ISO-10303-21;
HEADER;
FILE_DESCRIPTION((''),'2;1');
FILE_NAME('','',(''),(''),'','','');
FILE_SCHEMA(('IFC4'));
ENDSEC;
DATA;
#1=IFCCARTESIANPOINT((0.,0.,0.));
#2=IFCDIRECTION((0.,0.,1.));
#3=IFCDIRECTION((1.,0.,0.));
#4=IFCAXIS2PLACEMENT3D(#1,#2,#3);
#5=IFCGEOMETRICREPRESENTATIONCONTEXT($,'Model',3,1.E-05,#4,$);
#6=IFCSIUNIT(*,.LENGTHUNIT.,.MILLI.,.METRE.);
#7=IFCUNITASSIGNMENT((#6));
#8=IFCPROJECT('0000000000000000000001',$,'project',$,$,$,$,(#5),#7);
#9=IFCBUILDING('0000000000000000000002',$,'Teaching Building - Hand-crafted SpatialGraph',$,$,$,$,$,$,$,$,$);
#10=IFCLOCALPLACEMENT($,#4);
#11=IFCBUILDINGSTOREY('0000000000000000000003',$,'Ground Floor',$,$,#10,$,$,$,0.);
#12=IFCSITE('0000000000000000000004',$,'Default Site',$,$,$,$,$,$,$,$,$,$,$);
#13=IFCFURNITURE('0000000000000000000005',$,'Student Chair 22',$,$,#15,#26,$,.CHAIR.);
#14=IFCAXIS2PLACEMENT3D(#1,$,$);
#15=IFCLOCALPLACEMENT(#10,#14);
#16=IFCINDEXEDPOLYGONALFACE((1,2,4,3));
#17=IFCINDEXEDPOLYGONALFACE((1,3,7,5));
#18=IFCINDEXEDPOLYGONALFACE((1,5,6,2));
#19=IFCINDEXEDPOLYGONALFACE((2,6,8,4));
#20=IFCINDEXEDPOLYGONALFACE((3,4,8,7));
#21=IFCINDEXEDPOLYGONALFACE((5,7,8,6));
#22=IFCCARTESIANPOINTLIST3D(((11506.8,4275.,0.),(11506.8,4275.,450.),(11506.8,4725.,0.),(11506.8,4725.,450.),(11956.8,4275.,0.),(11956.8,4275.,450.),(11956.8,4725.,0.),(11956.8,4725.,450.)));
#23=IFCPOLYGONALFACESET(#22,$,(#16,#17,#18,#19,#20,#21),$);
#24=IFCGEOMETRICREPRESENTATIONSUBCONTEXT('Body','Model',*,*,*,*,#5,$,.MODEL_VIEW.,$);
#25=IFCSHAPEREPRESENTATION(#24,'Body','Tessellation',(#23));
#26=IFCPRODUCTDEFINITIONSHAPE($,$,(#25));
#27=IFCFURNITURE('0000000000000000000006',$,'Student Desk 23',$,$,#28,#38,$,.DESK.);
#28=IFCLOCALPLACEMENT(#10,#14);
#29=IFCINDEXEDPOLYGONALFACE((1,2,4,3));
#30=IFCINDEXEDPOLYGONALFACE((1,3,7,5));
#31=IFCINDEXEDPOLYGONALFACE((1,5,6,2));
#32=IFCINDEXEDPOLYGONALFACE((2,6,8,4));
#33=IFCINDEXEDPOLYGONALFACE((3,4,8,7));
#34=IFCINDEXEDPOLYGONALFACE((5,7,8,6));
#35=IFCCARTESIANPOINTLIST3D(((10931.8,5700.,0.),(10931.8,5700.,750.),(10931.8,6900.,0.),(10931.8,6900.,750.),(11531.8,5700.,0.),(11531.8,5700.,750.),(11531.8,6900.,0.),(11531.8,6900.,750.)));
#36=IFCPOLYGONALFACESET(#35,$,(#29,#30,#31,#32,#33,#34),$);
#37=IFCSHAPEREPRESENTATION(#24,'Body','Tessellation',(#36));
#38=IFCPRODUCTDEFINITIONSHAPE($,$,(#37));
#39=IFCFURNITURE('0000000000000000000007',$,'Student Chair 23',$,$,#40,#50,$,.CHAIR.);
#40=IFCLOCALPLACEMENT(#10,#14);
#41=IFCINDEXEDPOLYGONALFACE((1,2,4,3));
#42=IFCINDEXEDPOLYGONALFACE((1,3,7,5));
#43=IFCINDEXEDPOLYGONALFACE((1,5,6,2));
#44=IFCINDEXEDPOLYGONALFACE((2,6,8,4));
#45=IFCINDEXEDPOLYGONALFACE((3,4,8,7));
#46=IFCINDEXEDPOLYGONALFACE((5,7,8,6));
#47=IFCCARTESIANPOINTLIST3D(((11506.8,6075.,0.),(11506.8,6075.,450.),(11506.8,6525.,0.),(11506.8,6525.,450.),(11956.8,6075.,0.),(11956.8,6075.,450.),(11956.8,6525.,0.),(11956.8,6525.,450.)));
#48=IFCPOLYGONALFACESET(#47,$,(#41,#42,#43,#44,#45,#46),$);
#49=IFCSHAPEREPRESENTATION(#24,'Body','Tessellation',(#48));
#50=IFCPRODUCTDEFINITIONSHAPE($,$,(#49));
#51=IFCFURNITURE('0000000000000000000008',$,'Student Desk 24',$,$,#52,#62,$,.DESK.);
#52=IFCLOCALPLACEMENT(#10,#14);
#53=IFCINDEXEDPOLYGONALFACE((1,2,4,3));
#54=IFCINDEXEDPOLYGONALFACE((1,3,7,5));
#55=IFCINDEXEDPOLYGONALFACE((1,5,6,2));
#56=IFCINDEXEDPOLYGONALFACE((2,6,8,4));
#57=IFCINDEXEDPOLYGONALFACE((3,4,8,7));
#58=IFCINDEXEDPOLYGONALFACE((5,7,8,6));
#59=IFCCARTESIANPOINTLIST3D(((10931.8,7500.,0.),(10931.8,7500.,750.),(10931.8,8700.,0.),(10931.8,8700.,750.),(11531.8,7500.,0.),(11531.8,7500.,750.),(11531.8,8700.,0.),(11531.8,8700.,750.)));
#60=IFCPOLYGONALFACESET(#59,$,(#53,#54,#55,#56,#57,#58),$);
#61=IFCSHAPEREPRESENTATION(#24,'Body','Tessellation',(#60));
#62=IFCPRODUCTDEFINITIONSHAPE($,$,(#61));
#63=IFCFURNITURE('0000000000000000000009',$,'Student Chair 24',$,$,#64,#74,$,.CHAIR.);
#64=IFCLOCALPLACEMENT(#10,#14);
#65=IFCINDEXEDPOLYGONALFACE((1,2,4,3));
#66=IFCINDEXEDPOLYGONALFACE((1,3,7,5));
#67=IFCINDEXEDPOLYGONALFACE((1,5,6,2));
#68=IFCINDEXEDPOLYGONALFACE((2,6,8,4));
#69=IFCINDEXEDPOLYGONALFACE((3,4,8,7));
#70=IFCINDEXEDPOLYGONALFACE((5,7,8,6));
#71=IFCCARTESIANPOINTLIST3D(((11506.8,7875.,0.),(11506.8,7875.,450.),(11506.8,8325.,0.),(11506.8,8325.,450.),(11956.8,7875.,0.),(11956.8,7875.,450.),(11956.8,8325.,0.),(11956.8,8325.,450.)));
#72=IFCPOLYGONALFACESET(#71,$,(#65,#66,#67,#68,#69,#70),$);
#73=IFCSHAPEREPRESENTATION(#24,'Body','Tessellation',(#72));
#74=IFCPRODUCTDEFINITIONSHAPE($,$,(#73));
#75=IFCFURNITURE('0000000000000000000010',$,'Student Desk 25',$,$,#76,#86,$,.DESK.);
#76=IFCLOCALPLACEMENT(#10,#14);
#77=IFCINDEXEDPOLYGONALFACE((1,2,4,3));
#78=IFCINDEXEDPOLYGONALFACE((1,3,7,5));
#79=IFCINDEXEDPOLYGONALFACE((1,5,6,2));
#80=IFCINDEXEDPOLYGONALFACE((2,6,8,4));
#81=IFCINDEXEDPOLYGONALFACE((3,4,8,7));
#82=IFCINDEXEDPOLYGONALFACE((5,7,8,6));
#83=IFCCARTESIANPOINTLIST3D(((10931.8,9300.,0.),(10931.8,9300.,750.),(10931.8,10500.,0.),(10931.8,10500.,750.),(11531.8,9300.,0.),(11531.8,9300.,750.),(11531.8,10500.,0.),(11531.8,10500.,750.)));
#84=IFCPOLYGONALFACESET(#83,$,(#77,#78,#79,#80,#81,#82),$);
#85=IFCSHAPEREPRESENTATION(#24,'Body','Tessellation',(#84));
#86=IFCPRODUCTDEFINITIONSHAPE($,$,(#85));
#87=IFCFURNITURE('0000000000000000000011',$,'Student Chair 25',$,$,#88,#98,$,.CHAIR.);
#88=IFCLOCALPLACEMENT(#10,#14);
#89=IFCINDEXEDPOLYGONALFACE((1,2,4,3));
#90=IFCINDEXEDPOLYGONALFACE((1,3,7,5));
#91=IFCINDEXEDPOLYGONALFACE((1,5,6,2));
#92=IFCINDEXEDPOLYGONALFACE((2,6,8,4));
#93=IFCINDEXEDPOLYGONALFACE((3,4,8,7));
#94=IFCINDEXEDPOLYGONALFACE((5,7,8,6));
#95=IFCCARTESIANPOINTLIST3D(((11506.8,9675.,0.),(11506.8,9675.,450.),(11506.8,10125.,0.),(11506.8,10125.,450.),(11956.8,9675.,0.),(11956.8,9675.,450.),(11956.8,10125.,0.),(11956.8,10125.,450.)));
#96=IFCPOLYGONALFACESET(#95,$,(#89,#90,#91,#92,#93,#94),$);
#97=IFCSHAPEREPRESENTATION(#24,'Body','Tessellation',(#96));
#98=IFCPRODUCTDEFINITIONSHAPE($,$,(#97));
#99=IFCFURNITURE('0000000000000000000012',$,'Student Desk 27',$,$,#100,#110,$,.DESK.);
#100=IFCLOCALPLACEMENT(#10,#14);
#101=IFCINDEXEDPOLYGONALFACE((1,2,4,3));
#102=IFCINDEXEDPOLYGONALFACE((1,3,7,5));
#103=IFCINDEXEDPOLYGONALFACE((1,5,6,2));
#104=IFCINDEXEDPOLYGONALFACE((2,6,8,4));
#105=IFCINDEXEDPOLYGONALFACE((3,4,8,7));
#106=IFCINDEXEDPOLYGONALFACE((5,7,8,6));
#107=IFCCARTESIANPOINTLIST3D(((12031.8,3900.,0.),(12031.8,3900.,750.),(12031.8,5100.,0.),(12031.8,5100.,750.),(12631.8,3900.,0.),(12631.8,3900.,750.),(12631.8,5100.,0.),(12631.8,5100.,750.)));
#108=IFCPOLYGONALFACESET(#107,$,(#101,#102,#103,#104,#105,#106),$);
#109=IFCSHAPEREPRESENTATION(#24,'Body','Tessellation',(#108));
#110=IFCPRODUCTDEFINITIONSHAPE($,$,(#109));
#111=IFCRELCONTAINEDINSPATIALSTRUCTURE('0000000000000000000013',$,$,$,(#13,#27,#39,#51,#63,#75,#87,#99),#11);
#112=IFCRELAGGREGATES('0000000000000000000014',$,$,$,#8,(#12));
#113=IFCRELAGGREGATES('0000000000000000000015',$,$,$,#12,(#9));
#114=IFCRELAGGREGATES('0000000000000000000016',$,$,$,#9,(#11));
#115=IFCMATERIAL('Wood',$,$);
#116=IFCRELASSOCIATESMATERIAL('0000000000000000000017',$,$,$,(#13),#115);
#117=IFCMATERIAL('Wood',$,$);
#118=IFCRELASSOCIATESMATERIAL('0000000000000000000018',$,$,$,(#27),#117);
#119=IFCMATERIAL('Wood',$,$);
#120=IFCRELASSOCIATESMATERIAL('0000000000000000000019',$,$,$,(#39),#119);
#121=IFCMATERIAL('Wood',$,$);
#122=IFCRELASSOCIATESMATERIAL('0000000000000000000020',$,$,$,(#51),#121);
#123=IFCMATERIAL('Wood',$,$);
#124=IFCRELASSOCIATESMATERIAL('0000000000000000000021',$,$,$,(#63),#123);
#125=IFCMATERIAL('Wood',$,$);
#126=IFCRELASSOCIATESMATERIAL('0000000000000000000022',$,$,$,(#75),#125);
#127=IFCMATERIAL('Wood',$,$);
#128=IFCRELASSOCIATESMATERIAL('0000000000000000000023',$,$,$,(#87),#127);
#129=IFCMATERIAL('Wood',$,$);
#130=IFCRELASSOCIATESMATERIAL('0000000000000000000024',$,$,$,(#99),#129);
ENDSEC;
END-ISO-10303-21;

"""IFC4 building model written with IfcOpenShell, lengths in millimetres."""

from ifc_helpers import new_model, si_unit, frame, origin_with_axes, origin_2d, place, context, subcontext, project, spatial, rectangle, extrude, material, element, save


model = new_model("IFC4")

# Units and contexts
model_context = context("Model", 3, precision=1e-05, world=origin_with_axes())
body_context = subcontext(model_context, "Body", "Model", "MODEL_VIEW")
ifc_project = project(units=[si_unit("LENGTHUNIT", "METRE", prefix="MILLI")], contexts=[model_context])

# Site, building, storey
site = spatial("IfcSite", under=ifc_project, Name="Default Site")
building = spatial("IfcBuilding", under=site, Name="Teaching Building - Hand-crafted SpatialGraph")
storey_placement = place(None, origin_with_axes())
storey = spatial("IfcBuildingStorey", under=building, at=storey_placement, Name="Ground Floor", Elevation=0.0)

# Furniture
ifc_material_1 = material(Name="Wood")
furniture_1_placement = place(storey_placement, frame((11731.8, 4500.0, 0.0), z_axis=(0.0, 0.0, 1.0), x_axis=(1.0, 0.0, 0.0)))
element("IfcFurniture", 1, at=furniture_1_placement, inside=storey, material=ifc_material_1, Name="Student Chair 22", PredefinedType="CHAIR", context=body_context, shape_type="SweptSolid", body=[
    extrude(rectangle(XDim=450.0, YDim=450.0, at=origin_2d()), origin_with_axes(), (0.0, 0.0, 1.0), 450.0),
])
ifc_material_2 = material(Name="Wood")
furniture_2_placement = place(storey_placement, frame((11231.8, 6300.0, 0.0), z_axis=(0.0, 0.0, 1.0), x_axis=(0.0, 1.0, 0.0)))
element("IfcFurniture", 2, at=furniture_2_placement, inside=storey, material=ifc_material_2, Name="Student Desk 23", PredefinedType="DESK", context=body_context, shape_type="SweptSolid", body=[
    extrude(rectangle(XDim=1200.0, YDim=600.0, at=origin_2d()), origin_with_axes(), (0.0, 0.0, 1.0), 750.0),
])
ifc_material_3 = material(Name="Wood")
furniture_3_placement = place(storey_placement, frame((11731.8, 6300.0, 0.0), z_axis=(0.0, 0.0, 1.0), x_axis=(1.0, 0.0, 0.0)))
element("IfcFurniture", 3, at=furniture_3_placement, inside=storey, material=ifc_material_3, Name="Student Chair 23", PredefinedType="CHAIR", context=body_context, shape_type="SweptSolid", body=[
    extrude(rectangle(XDim=450.0, YDim=450.0, at=origin_2d()), origin_with_axes(), (0.0, 0.0, 1.0), 450.0),
])
ifc_material_4 = material(Name="Wood")
furniture_4_placement = place(storey_placement, frame((11231.8, 8100.0, 0.0), z_axis=(0.0, 0.0, 1.0), x_axis=(0.0, 1.0, 0.0)))
element("IfcFurniture", 4, at=furniture_4_placement, inside=storey, material=ifc_material_4, Name="Student Desk 24", PredefinedType="DESK", context=body_context, shape_type="SweptSolid", body=[
    extrude(rectangle(XDim=1200.0, YDim=600.0, at=origin_2d()), origin_with_axes(), (0.0, 0.0, 1.0), 750.0),
])
ifc_material_5 = material(Name="Wood")
furniture_5_placement = place(storey_placement, frame((11731.8, 8100.0, 0.0), z_axis=(0.0, 0.0, 1.0), x_axis=(1.0, 0.0, 0.0)))
element("IfcFurniture", 5, at=furniture_5_placement, inside=storey, material=ifc_material_5, Name="Student Chair 24", PredefinedType="CHAIR", context=body_context, shape_type="SweptSolid", body=[
    extrude(rectangle(XDim=450.0, YDim=450.0, at=origin_2d()), origin_with_axes(), (0.0, 0.0, 1.0), 450.0),
])
ifc_material_6 = material(Name="Wood")
furniture_6_placement = place(storey_placement, frame((11231.8, 9900.0, 0.0), z_axis=(0.0, 0.0, 1.0), x_axis=(0.0, 1.0, 0.0)))
element("IfcFurniture", 6, at=furniture_6_placement, inside=storey, material=ifc_material_6, Name="Student Desk 25", PredefinedType="DESK", context=body_context, shape_type="SweptSolid", body=[
    extrude(rectangle(XDim=1200.0, YDim=600.0, at=origin_2d()), origin_with_axes(), (0.0, 0.0, 1.0), 750.0),
])
ifc_material_7 = material(Name="Wood")
furniture_7_placement = place(storey_placement, frame((11731.8, 9900.0, 0.0), z_axis=(0.0, 0.0, 1.0), x_axis=(1.0, 0.0, 0.0)))
element("IfcFurniture", 7, at=furniture_7_placement, inside=storey, material=ifc_material_7, Name="Student Chair 25", PredefinedType="CHAIR", context=body_context, shape_type="SweptSolid", body=[
    extrude(rectangle(XDim=450.0, YDim=450.0, at=origin_2d()), origin_with_axes(), (0.0, 0.0, 1.0), 450.0),
])
ifc_material_8 = material(Name="Wood")
furniture_8_placement = place(storey_placement, frame((12331.8, 4500.0, 0.0), z_axis=(0.0, 0.0, 1.0), x_axis=(0.0, 1.0, 0.0)))
element("IfcFurniture", 8, at=furniture_8_placement, inside=storey, material=ifc_material_8, Name="Student Desk 27", PredefinedType="DESK", context=body_context, shape_type="SweptSolid", body=[
    extrude(rectangle(XDim=1200.0, YDim=600.0, at=origin_2d()), origin_with_axes(), (0.0, 0.0, 1.0), 750.0),
])

save(model, "model.ifc")
